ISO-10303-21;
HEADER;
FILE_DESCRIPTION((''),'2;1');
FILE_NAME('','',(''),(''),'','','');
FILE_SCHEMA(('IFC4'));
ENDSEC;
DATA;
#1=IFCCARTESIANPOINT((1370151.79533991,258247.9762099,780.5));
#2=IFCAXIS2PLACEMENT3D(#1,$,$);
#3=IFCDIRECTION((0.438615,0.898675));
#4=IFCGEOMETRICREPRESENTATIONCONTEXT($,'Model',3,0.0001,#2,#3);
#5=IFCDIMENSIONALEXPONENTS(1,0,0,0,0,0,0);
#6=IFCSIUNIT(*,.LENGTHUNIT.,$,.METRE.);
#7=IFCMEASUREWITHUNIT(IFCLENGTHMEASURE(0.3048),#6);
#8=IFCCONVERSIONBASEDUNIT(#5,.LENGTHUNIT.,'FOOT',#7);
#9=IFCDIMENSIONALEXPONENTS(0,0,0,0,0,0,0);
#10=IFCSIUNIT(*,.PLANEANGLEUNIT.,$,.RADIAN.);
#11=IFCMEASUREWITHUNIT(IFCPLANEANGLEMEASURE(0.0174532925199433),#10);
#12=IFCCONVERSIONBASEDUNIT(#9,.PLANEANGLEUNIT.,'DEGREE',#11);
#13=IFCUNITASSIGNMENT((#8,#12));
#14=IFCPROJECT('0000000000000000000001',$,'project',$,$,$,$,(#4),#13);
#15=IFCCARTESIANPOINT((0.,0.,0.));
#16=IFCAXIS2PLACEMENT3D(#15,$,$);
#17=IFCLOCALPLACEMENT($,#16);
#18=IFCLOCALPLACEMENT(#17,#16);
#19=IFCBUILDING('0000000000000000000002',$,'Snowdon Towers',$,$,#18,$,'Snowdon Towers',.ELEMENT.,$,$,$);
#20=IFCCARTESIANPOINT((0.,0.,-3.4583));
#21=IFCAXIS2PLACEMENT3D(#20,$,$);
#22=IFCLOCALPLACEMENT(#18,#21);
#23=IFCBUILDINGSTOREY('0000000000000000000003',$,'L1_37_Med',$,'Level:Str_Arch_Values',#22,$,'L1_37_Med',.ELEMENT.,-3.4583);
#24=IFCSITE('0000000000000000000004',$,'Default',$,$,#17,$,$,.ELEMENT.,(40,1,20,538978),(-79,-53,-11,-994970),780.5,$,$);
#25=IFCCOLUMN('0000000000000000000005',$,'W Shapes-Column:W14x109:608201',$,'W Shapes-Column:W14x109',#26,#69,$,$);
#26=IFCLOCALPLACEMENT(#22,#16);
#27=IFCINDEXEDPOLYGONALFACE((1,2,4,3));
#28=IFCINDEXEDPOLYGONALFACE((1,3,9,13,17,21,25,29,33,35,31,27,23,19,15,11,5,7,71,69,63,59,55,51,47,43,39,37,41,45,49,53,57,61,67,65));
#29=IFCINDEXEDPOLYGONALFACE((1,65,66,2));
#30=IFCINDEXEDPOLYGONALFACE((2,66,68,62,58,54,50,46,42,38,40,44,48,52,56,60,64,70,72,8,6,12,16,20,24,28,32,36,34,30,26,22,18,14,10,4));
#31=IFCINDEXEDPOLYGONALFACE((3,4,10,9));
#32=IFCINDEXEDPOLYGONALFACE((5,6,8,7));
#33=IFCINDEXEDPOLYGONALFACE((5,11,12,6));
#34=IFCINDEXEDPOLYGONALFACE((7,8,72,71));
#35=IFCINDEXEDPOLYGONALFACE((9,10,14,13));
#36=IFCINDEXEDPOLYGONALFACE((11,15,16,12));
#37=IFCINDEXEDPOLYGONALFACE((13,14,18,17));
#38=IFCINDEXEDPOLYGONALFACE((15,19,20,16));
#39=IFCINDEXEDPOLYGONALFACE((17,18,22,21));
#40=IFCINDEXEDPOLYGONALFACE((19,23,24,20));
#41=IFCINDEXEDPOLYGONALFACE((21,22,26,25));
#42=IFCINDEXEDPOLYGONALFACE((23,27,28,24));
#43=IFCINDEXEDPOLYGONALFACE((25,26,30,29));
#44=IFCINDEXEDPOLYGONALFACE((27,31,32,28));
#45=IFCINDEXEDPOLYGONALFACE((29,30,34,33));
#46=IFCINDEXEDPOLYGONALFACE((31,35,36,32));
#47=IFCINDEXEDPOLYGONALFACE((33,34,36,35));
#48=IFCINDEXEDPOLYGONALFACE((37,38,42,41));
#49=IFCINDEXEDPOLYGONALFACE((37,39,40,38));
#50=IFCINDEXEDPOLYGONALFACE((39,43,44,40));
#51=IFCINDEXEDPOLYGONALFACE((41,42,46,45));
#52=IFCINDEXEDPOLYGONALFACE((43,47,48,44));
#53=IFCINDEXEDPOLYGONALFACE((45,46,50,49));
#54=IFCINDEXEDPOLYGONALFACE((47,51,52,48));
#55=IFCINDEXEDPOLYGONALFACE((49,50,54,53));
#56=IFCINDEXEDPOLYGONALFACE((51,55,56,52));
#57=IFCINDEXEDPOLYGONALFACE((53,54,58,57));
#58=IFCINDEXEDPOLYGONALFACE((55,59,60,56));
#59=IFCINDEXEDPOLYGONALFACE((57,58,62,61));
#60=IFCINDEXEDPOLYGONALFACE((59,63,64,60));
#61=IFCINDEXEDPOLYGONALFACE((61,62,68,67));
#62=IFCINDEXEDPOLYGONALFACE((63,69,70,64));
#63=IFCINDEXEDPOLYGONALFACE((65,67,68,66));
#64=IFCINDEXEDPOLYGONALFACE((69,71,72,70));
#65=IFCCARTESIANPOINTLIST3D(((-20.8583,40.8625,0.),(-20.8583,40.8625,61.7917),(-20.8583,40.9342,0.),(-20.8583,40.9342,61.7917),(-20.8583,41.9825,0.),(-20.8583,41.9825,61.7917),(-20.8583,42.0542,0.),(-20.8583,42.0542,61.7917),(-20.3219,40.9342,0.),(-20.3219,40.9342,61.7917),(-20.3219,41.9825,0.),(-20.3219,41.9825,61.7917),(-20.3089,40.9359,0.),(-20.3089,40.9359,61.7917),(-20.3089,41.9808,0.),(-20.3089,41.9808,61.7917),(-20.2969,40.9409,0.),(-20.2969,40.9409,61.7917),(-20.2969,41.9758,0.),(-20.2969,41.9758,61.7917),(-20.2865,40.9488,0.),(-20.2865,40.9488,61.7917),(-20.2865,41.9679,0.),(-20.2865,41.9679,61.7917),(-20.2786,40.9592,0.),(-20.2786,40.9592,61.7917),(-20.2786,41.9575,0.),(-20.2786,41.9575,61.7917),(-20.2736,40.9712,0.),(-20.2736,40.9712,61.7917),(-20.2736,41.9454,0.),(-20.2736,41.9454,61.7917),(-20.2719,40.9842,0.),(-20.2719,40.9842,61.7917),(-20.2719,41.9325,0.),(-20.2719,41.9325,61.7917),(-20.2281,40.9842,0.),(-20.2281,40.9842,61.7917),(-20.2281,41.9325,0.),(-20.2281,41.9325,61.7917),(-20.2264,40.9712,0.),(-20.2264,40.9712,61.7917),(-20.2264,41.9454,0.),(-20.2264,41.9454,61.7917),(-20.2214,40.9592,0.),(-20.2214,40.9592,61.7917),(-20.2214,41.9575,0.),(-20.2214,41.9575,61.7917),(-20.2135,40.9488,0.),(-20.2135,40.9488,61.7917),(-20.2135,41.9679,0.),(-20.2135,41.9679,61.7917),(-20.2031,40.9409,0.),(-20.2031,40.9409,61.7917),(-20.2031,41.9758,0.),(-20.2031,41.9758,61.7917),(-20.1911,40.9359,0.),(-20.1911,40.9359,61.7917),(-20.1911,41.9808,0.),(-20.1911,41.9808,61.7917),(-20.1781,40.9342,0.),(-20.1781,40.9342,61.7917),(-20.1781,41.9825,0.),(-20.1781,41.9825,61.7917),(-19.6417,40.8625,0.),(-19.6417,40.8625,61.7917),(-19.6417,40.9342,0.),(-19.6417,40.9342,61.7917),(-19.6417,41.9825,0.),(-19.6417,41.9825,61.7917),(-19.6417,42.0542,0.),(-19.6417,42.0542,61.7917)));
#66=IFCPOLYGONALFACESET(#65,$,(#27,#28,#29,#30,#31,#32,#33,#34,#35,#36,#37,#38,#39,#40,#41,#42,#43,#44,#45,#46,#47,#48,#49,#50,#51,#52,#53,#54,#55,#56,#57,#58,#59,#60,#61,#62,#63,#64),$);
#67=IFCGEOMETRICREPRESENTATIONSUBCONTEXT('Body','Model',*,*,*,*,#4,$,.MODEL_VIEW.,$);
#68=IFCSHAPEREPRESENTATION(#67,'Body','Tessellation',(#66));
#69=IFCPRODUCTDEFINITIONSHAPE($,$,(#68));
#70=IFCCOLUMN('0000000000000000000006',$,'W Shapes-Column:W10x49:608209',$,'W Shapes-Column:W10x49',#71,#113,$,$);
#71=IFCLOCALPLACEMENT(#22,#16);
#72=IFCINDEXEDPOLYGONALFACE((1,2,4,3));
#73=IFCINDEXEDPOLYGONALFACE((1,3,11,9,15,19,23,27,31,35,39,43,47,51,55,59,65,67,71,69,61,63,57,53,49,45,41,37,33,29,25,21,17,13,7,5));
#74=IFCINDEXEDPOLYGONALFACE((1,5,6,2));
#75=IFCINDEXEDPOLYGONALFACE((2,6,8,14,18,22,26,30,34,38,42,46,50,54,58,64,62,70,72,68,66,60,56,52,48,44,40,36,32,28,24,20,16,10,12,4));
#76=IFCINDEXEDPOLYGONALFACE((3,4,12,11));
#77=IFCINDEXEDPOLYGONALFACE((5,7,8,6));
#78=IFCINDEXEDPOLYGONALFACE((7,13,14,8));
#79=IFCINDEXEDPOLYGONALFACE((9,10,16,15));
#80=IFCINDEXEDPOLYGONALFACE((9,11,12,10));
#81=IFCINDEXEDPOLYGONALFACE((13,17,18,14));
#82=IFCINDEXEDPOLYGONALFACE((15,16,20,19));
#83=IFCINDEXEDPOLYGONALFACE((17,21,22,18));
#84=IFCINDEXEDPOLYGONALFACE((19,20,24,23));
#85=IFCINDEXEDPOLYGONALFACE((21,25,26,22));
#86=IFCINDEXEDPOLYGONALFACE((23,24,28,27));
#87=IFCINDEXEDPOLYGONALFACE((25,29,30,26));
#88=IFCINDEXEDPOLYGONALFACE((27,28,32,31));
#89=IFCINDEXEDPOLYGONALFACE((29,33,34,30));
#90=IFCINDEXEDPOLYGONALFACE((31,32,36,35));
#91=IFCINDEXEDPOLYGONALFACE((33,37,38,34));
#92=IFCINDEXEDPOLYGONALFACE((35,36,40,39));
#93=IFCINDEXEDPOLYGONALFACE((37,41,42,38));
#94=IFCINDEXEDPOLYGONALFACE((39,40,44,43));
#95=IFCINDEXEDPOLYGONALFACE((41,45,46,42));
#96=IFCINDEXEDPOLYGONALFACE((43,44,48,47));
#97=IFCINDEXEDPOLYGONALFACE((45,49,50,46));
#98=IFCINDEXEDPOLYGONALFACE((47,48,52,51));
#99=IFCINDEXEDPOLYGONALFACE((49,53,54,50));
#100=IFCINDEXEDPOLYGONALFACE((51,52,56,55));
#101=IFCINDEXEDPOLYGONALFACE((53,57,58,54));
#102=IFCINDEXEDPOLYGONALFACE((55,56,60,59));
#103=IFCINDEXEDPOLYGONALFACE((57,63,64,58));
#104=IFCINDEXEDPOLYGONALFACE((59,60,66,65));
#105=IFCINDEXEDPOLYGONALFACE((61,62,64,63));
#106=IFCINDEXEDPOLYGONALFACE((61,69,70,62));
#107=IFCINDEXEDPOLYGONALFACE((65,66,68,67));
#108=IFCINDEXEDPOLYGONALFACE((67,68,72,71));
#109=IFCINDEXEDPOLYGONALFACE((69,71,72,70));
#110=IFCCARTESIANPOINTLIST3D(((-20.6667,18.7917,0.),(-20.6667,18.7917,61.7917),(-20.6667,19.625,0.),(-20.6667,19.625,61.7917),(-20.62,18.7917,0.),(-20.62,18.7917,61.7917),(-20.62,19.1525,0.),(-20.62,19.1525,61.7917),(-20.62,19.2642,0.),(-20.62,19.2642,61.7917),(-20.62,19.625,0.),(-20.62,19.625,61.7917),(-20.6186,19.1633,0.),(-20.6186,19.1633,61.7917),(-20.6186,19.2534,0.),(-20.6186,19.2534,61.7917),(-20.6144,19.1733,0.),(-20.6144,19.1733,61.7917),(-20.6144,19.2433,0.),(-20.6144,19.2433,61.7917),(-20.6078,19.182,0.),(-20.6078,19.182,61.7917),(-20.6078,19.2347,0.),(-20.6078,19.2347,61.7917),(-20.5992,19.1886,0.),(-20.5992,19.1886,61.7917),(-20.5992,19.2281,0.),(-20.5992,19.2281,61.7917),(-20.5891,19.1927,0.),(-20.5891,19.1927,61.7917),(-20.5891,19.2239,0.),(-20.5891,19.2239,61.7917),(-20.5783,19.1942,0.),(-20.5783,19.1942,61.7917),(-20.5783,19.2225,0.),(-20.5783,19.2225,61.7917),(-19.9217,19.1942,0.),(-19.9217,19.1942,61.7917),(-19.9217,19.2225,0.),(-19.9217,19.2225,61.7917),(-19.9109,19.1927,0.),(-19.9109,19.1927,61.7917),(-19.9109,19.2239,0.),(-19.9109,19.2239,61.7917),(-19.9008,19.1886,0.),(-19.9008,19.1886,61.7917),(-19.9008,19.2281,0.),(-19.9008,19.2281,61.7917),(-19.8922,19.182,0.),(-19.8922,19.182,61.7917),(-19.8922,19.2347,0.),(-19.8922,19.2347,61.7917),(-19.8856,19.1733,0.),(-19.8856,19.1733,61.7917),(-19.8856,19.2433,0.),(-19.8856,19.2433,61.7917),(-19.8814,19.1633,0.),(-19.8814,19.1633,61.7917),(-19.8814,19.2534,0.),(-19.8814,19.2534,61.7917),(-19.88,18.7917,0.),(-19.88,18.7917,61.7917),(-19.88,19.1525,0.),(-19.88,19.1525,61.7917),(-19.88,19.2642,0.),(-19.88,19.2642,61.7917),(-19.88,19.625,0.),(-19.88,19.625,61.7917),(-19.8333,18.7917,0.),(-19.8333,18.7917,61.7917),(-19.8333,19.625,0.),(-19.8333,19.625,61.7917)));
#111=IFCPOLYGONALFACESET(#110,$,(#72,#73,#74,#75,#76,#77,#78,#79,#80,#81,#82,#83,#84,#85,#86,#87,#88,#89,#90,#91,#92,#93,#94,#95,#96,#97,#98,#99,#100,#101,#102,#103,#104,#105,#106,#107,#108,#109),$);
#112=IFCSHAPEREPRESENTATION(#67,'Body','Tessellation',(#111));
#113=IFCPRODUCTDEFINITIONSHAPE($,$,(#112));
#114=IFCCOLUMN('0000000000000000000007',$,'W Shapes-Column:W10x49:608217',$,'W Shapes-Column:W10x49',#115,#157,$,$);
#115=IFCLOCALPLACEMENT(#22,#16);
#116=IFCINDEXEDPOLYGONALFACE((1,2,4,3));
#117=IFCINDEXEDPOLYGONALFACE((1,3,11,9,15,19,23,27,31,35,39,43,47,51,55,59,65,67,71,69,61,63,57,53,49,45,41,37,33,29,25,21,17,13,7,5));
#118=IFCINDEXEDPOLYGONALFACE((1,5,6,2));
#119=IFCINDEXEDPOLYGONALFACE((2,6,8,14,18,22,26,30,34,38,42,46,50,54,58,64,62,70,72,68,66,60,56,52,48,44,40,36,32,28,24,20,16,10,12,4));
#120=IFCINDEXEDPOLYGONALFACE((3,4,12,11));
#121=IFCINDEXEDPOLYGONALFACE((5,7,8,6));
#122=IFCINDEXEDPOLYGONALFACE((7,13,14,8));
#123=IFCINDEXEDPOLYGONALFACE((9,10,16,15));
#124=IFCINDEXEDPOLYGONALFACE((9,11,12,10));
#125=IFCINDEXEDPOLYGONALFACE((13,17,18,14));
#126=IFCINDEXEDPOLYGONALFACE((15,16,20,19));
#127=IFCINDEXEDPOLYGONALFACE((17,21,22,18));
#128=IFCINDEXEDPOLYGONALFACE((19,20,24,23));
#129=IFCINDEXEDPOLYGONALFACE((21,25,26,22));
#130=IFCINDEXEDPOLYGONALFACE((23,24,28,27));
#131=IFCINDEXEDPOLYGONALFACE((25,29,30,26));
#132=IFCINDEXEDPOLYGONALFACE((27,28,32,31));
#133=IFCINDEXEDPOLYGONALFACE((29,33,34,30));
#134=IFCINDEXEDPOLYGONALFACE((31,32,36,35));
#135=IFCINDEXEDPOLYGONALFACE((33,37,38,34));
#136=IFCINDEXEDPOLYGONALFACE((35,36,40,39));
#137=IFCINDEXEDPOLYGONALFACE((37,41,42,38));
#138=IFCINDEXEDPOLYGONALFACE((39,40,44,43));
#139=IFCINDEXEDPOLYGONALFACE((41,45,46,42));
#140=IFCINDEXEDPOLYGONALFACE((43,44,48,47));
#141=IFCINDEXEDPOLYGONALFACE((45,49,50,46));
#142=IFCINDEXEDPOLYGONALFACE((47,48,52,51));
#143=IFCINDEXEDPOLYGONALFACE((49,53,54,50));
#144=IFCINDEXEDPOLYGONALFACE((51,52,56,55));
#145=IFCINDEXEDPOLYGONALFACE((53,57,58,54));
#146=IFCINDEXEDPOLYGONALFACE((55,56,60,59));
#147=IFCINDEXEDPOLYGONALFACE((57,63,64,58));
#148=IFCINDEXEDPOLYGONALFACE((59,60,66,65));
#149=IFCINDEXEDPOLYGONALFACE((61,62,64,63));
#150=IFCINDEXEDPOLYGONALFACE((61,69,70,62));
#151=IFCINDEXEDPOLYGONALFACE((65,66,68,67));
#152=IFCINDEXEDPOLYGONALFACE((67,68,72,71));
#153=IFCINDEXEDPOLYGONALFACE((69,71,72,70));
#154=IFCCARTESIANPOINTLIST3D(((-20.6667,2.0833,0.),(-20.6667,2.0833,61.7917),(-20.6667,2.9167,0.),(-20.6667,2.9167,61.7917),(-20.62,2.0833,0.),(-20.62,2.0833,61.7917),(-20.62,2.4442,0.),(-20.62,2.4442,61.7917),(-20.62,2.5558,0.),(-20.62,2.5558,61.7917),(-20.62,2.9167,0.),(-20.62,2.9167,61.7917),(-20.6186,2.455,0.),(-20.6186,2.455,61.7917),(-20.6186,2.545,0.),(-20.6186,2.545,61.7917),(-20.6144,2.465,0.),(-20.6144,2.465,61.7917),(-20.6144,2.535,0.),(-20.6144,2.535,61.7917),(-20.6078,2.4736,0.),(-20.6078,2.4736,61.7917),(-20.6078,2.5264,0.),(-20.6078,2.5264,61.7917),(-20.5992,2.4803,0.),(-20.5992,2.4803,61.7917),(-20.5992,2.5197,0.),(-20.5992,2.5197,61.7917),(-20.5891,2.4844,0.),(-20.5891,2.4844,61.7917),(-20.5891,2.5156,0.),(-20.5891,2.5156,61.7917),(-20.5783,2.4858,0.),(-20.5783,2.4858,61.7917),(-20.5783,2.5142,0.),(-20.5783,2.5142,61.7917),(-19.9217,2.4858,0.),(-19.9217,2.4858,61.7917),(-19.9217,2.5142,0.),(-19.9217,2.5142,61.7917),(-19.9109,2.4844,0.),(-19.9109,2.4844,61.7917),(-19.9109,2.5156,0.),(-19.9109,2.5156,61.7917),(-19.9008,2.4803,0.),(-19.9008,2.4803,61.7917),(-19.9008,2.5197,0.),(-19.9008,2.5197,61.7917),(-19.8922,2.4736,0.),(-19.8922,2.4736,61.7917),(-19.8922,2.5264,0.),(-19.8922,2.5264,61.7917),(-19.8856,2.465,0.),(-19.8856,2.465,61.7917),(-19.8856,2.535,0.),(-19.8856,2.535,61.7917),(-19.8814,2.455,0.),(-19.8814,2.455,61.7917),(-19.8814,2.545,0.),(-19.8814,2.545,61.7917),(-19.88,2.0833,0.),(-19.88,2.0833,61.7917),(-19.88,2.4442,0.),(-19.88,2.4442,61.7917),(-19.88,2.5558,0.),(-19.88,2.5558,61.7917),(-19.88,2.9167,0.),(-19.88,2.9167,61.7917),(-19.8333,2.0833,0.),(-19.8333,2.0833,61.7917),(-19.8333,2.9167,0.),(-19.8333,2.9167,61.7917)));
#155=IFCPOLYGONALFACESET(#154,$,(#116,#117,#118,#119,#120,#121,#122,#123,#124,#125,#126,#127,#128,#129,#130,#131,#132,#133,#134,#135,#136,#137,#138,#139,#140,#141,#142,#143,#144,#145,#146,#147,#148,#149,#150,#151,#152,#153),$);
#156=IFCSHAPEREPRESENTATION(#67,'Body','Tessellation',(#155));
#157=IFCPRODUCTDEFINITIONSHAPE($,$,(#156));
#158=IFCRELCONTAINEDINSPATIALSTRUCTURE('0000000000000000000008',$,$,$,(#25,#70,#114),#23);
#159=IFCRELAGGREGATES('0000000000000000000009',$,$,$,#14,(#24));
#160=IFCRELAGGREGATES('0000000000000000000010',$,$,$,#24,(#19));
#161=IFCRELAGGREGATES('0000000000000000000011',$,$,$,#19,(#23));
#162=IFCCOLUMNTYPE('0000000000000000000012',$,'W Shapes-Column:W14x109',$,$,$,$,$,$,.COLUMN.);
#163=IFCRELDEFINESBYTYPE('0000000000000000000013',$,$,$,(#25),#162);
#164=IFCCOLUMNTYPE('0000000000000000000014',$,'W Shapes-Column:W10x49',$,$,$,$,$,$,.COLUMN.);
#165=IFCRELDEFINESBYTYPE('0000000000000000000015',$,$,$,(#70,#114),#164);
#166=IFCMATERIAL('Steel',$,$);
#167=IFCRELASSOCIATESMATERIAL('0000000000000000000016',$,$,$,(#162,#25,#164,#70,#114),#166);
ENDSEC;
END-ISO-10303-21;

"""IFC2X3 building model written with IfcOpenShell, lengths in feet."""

from ifc_helpers import new_model, entity, si_unit, converted_unit, direction, frame, frame_2d, origin, place, context, subcontext, project, spatial, i_section, extrude, source, transform, mapped, material, type_object, type_shapes, element, save


model = new_model("IFC2X3")

# Units and contexts
model_context = context("Model", 3, precision=0.0001, world=frame((1370151.79533991, 258247.9762099, 780.5)), true_north=direction((0.438615, 0.898675)))
body_context = subcontext(model_context, "Body", "Model", "MODEL_VIEW")
ifc_project = project(units=[converted_unit("LENGTHUNIT", "FOOT", entity("IfcLengthMeasure", 0.3048), si_unit("LENGTHUNIT", "METRE"), dimensions=[1, 0, 0, 0, 0, 0, 0]), converted_unit("PLANEANGLEUNIT", "DEGREE", entity("IfcPlaneAngleMeasure", 0.0174532925199433), si_unit("PLANEANGLEUNIT", "RADIAN"), dimensions=[0, 0, 0, 0, 0, 0, 0])], contexts=[model_context])

# Site, building, storey
site_placement = place(None, origin())
site = spatial("IfcSite", under=ifc_project, at=site_placement, Name="Default", CompositionType="ELEMENT", RefLatitude=(40, 1, 20, 538978), RefLongitude=(-79, -53, -11, -994970), RefElevation=780.5)
building_placement = place(site_placement, origin())
building = spatial("IfcBuilding", under=site, at=building_placement, Name="Snowdon Towers", LongName="Snowdon Towers", CompositionType="ELEMENT")
storey_placement = place(building_placement, frame((0.0, 0.0, -3.4583)))
storey = spatial("IfcBuildingStorey", under=building, at=storey_placement, Name="L1_37_Med", ObjectType="Level:Str_Arch_Values", LongName="L1_37_Med", CompositionType="ELEMENT", Elevation=-3.4583)

# Columns
ifc_material_1 = material(Name="Steel")
column_type_1 = type_object("IfcColumnType", Name="W Shapes-Column:W14x109", PredefinedType="COLUMN", material=ifc_material_1)
shared_shape_1 = source(origin(), body_context, "Body", "SweptSolid", [
    extrude(i_section(OverallWidth=1.2167, OverallDepth=1.1917, WebThickness=0.0438, FlangeThickness=0.0717, FilletRadius=0.05, at=frame_2d((0.0, 0.0), x_axis=(1.0, 0.0))), frame((0.0, 0.0, -3.4583), z_axis=(0.0, 0.0, 1.0), x_axis=(-1.0, 0.0, 0.0)), (0.0, 0.0, 1.0), 61.7917),
])
type_shapes(column_type_1, [shared_shape_1])
column_1_placement = place(storey_placement, frame((-20.25, 41.4583, 3.4583), z_axis=(0.0, 0.0, 1.0), x_axis=(-1.0, 0.0, 0.0)))
element("IfcColumn", 1, at=column_1_placement, inside=storey, type_object=column_type_1, material=ifc_material_1, Name="W Shapes-Column:W14x109:608201", ObjectType="W Shapes-Column:W14x109", context=body_context, shape_type="MappedRepresentation", body=[
    mapped(shared_shape_1, transform((0.0, 0.0, 0.0), scale=1.0)),
])
column_type_2 = type_object("IfcColumnType", Name="W Shapes-Column:W10x49", PredefinedType="COLUMN", material=ifc_material_1)
shared_shape_2 = source(origin(), body_context, "Body", "SweptSolid", [
    extrude(i_section(OverallWidth=0.8333, OverallDepth=0.8333, WebThickness=0.0283, FlangeThickness=0.0467, FilletRadius=0.0417, at=frame_2d((0.0, 0.0), x_axis=(1.0, 0.0))), frame((0.0, 0.0, -3.4583), z_axis=(0.0, 0.0, 1.0), x_axis=(-1.0, 0.0, 0.0)), (0.0, 0.0, 1.0), 61.7917),
])
type_shapes(column_type_2, [shared_shape_2])
for number, where, z_axis, x_axis, name in (
    (2, (-20.25, 19.2083, 3.4583), (0.0, 0.0, 1.0), (0.0, 1.0, 0.0), "W Shapes-Column:W10x49:608209"),
    (3, (-20.25, 2.5, 3.4583), (0.0, 0.0, 1.0), (0.0, 1.0, 0.0), "W Shapes-Column:W10x49:608217"),
):
    element("IfcColumn", number, at=place(storey_placement, frame(where, z_axis=z_axis, x_axis=x_axis)), inside=storey, type_object=column_type_2, material=ifc_material_1, Name=name, ObjectType="W Shapes-Column:W10x49", context=body_context, shape_type="MappedRepresentation", body=[
        mapped(shared_shape_2, transform((0.0, 0.0, 0.0), scale=1.0)),
    ])

save(model, "model.ifc")
